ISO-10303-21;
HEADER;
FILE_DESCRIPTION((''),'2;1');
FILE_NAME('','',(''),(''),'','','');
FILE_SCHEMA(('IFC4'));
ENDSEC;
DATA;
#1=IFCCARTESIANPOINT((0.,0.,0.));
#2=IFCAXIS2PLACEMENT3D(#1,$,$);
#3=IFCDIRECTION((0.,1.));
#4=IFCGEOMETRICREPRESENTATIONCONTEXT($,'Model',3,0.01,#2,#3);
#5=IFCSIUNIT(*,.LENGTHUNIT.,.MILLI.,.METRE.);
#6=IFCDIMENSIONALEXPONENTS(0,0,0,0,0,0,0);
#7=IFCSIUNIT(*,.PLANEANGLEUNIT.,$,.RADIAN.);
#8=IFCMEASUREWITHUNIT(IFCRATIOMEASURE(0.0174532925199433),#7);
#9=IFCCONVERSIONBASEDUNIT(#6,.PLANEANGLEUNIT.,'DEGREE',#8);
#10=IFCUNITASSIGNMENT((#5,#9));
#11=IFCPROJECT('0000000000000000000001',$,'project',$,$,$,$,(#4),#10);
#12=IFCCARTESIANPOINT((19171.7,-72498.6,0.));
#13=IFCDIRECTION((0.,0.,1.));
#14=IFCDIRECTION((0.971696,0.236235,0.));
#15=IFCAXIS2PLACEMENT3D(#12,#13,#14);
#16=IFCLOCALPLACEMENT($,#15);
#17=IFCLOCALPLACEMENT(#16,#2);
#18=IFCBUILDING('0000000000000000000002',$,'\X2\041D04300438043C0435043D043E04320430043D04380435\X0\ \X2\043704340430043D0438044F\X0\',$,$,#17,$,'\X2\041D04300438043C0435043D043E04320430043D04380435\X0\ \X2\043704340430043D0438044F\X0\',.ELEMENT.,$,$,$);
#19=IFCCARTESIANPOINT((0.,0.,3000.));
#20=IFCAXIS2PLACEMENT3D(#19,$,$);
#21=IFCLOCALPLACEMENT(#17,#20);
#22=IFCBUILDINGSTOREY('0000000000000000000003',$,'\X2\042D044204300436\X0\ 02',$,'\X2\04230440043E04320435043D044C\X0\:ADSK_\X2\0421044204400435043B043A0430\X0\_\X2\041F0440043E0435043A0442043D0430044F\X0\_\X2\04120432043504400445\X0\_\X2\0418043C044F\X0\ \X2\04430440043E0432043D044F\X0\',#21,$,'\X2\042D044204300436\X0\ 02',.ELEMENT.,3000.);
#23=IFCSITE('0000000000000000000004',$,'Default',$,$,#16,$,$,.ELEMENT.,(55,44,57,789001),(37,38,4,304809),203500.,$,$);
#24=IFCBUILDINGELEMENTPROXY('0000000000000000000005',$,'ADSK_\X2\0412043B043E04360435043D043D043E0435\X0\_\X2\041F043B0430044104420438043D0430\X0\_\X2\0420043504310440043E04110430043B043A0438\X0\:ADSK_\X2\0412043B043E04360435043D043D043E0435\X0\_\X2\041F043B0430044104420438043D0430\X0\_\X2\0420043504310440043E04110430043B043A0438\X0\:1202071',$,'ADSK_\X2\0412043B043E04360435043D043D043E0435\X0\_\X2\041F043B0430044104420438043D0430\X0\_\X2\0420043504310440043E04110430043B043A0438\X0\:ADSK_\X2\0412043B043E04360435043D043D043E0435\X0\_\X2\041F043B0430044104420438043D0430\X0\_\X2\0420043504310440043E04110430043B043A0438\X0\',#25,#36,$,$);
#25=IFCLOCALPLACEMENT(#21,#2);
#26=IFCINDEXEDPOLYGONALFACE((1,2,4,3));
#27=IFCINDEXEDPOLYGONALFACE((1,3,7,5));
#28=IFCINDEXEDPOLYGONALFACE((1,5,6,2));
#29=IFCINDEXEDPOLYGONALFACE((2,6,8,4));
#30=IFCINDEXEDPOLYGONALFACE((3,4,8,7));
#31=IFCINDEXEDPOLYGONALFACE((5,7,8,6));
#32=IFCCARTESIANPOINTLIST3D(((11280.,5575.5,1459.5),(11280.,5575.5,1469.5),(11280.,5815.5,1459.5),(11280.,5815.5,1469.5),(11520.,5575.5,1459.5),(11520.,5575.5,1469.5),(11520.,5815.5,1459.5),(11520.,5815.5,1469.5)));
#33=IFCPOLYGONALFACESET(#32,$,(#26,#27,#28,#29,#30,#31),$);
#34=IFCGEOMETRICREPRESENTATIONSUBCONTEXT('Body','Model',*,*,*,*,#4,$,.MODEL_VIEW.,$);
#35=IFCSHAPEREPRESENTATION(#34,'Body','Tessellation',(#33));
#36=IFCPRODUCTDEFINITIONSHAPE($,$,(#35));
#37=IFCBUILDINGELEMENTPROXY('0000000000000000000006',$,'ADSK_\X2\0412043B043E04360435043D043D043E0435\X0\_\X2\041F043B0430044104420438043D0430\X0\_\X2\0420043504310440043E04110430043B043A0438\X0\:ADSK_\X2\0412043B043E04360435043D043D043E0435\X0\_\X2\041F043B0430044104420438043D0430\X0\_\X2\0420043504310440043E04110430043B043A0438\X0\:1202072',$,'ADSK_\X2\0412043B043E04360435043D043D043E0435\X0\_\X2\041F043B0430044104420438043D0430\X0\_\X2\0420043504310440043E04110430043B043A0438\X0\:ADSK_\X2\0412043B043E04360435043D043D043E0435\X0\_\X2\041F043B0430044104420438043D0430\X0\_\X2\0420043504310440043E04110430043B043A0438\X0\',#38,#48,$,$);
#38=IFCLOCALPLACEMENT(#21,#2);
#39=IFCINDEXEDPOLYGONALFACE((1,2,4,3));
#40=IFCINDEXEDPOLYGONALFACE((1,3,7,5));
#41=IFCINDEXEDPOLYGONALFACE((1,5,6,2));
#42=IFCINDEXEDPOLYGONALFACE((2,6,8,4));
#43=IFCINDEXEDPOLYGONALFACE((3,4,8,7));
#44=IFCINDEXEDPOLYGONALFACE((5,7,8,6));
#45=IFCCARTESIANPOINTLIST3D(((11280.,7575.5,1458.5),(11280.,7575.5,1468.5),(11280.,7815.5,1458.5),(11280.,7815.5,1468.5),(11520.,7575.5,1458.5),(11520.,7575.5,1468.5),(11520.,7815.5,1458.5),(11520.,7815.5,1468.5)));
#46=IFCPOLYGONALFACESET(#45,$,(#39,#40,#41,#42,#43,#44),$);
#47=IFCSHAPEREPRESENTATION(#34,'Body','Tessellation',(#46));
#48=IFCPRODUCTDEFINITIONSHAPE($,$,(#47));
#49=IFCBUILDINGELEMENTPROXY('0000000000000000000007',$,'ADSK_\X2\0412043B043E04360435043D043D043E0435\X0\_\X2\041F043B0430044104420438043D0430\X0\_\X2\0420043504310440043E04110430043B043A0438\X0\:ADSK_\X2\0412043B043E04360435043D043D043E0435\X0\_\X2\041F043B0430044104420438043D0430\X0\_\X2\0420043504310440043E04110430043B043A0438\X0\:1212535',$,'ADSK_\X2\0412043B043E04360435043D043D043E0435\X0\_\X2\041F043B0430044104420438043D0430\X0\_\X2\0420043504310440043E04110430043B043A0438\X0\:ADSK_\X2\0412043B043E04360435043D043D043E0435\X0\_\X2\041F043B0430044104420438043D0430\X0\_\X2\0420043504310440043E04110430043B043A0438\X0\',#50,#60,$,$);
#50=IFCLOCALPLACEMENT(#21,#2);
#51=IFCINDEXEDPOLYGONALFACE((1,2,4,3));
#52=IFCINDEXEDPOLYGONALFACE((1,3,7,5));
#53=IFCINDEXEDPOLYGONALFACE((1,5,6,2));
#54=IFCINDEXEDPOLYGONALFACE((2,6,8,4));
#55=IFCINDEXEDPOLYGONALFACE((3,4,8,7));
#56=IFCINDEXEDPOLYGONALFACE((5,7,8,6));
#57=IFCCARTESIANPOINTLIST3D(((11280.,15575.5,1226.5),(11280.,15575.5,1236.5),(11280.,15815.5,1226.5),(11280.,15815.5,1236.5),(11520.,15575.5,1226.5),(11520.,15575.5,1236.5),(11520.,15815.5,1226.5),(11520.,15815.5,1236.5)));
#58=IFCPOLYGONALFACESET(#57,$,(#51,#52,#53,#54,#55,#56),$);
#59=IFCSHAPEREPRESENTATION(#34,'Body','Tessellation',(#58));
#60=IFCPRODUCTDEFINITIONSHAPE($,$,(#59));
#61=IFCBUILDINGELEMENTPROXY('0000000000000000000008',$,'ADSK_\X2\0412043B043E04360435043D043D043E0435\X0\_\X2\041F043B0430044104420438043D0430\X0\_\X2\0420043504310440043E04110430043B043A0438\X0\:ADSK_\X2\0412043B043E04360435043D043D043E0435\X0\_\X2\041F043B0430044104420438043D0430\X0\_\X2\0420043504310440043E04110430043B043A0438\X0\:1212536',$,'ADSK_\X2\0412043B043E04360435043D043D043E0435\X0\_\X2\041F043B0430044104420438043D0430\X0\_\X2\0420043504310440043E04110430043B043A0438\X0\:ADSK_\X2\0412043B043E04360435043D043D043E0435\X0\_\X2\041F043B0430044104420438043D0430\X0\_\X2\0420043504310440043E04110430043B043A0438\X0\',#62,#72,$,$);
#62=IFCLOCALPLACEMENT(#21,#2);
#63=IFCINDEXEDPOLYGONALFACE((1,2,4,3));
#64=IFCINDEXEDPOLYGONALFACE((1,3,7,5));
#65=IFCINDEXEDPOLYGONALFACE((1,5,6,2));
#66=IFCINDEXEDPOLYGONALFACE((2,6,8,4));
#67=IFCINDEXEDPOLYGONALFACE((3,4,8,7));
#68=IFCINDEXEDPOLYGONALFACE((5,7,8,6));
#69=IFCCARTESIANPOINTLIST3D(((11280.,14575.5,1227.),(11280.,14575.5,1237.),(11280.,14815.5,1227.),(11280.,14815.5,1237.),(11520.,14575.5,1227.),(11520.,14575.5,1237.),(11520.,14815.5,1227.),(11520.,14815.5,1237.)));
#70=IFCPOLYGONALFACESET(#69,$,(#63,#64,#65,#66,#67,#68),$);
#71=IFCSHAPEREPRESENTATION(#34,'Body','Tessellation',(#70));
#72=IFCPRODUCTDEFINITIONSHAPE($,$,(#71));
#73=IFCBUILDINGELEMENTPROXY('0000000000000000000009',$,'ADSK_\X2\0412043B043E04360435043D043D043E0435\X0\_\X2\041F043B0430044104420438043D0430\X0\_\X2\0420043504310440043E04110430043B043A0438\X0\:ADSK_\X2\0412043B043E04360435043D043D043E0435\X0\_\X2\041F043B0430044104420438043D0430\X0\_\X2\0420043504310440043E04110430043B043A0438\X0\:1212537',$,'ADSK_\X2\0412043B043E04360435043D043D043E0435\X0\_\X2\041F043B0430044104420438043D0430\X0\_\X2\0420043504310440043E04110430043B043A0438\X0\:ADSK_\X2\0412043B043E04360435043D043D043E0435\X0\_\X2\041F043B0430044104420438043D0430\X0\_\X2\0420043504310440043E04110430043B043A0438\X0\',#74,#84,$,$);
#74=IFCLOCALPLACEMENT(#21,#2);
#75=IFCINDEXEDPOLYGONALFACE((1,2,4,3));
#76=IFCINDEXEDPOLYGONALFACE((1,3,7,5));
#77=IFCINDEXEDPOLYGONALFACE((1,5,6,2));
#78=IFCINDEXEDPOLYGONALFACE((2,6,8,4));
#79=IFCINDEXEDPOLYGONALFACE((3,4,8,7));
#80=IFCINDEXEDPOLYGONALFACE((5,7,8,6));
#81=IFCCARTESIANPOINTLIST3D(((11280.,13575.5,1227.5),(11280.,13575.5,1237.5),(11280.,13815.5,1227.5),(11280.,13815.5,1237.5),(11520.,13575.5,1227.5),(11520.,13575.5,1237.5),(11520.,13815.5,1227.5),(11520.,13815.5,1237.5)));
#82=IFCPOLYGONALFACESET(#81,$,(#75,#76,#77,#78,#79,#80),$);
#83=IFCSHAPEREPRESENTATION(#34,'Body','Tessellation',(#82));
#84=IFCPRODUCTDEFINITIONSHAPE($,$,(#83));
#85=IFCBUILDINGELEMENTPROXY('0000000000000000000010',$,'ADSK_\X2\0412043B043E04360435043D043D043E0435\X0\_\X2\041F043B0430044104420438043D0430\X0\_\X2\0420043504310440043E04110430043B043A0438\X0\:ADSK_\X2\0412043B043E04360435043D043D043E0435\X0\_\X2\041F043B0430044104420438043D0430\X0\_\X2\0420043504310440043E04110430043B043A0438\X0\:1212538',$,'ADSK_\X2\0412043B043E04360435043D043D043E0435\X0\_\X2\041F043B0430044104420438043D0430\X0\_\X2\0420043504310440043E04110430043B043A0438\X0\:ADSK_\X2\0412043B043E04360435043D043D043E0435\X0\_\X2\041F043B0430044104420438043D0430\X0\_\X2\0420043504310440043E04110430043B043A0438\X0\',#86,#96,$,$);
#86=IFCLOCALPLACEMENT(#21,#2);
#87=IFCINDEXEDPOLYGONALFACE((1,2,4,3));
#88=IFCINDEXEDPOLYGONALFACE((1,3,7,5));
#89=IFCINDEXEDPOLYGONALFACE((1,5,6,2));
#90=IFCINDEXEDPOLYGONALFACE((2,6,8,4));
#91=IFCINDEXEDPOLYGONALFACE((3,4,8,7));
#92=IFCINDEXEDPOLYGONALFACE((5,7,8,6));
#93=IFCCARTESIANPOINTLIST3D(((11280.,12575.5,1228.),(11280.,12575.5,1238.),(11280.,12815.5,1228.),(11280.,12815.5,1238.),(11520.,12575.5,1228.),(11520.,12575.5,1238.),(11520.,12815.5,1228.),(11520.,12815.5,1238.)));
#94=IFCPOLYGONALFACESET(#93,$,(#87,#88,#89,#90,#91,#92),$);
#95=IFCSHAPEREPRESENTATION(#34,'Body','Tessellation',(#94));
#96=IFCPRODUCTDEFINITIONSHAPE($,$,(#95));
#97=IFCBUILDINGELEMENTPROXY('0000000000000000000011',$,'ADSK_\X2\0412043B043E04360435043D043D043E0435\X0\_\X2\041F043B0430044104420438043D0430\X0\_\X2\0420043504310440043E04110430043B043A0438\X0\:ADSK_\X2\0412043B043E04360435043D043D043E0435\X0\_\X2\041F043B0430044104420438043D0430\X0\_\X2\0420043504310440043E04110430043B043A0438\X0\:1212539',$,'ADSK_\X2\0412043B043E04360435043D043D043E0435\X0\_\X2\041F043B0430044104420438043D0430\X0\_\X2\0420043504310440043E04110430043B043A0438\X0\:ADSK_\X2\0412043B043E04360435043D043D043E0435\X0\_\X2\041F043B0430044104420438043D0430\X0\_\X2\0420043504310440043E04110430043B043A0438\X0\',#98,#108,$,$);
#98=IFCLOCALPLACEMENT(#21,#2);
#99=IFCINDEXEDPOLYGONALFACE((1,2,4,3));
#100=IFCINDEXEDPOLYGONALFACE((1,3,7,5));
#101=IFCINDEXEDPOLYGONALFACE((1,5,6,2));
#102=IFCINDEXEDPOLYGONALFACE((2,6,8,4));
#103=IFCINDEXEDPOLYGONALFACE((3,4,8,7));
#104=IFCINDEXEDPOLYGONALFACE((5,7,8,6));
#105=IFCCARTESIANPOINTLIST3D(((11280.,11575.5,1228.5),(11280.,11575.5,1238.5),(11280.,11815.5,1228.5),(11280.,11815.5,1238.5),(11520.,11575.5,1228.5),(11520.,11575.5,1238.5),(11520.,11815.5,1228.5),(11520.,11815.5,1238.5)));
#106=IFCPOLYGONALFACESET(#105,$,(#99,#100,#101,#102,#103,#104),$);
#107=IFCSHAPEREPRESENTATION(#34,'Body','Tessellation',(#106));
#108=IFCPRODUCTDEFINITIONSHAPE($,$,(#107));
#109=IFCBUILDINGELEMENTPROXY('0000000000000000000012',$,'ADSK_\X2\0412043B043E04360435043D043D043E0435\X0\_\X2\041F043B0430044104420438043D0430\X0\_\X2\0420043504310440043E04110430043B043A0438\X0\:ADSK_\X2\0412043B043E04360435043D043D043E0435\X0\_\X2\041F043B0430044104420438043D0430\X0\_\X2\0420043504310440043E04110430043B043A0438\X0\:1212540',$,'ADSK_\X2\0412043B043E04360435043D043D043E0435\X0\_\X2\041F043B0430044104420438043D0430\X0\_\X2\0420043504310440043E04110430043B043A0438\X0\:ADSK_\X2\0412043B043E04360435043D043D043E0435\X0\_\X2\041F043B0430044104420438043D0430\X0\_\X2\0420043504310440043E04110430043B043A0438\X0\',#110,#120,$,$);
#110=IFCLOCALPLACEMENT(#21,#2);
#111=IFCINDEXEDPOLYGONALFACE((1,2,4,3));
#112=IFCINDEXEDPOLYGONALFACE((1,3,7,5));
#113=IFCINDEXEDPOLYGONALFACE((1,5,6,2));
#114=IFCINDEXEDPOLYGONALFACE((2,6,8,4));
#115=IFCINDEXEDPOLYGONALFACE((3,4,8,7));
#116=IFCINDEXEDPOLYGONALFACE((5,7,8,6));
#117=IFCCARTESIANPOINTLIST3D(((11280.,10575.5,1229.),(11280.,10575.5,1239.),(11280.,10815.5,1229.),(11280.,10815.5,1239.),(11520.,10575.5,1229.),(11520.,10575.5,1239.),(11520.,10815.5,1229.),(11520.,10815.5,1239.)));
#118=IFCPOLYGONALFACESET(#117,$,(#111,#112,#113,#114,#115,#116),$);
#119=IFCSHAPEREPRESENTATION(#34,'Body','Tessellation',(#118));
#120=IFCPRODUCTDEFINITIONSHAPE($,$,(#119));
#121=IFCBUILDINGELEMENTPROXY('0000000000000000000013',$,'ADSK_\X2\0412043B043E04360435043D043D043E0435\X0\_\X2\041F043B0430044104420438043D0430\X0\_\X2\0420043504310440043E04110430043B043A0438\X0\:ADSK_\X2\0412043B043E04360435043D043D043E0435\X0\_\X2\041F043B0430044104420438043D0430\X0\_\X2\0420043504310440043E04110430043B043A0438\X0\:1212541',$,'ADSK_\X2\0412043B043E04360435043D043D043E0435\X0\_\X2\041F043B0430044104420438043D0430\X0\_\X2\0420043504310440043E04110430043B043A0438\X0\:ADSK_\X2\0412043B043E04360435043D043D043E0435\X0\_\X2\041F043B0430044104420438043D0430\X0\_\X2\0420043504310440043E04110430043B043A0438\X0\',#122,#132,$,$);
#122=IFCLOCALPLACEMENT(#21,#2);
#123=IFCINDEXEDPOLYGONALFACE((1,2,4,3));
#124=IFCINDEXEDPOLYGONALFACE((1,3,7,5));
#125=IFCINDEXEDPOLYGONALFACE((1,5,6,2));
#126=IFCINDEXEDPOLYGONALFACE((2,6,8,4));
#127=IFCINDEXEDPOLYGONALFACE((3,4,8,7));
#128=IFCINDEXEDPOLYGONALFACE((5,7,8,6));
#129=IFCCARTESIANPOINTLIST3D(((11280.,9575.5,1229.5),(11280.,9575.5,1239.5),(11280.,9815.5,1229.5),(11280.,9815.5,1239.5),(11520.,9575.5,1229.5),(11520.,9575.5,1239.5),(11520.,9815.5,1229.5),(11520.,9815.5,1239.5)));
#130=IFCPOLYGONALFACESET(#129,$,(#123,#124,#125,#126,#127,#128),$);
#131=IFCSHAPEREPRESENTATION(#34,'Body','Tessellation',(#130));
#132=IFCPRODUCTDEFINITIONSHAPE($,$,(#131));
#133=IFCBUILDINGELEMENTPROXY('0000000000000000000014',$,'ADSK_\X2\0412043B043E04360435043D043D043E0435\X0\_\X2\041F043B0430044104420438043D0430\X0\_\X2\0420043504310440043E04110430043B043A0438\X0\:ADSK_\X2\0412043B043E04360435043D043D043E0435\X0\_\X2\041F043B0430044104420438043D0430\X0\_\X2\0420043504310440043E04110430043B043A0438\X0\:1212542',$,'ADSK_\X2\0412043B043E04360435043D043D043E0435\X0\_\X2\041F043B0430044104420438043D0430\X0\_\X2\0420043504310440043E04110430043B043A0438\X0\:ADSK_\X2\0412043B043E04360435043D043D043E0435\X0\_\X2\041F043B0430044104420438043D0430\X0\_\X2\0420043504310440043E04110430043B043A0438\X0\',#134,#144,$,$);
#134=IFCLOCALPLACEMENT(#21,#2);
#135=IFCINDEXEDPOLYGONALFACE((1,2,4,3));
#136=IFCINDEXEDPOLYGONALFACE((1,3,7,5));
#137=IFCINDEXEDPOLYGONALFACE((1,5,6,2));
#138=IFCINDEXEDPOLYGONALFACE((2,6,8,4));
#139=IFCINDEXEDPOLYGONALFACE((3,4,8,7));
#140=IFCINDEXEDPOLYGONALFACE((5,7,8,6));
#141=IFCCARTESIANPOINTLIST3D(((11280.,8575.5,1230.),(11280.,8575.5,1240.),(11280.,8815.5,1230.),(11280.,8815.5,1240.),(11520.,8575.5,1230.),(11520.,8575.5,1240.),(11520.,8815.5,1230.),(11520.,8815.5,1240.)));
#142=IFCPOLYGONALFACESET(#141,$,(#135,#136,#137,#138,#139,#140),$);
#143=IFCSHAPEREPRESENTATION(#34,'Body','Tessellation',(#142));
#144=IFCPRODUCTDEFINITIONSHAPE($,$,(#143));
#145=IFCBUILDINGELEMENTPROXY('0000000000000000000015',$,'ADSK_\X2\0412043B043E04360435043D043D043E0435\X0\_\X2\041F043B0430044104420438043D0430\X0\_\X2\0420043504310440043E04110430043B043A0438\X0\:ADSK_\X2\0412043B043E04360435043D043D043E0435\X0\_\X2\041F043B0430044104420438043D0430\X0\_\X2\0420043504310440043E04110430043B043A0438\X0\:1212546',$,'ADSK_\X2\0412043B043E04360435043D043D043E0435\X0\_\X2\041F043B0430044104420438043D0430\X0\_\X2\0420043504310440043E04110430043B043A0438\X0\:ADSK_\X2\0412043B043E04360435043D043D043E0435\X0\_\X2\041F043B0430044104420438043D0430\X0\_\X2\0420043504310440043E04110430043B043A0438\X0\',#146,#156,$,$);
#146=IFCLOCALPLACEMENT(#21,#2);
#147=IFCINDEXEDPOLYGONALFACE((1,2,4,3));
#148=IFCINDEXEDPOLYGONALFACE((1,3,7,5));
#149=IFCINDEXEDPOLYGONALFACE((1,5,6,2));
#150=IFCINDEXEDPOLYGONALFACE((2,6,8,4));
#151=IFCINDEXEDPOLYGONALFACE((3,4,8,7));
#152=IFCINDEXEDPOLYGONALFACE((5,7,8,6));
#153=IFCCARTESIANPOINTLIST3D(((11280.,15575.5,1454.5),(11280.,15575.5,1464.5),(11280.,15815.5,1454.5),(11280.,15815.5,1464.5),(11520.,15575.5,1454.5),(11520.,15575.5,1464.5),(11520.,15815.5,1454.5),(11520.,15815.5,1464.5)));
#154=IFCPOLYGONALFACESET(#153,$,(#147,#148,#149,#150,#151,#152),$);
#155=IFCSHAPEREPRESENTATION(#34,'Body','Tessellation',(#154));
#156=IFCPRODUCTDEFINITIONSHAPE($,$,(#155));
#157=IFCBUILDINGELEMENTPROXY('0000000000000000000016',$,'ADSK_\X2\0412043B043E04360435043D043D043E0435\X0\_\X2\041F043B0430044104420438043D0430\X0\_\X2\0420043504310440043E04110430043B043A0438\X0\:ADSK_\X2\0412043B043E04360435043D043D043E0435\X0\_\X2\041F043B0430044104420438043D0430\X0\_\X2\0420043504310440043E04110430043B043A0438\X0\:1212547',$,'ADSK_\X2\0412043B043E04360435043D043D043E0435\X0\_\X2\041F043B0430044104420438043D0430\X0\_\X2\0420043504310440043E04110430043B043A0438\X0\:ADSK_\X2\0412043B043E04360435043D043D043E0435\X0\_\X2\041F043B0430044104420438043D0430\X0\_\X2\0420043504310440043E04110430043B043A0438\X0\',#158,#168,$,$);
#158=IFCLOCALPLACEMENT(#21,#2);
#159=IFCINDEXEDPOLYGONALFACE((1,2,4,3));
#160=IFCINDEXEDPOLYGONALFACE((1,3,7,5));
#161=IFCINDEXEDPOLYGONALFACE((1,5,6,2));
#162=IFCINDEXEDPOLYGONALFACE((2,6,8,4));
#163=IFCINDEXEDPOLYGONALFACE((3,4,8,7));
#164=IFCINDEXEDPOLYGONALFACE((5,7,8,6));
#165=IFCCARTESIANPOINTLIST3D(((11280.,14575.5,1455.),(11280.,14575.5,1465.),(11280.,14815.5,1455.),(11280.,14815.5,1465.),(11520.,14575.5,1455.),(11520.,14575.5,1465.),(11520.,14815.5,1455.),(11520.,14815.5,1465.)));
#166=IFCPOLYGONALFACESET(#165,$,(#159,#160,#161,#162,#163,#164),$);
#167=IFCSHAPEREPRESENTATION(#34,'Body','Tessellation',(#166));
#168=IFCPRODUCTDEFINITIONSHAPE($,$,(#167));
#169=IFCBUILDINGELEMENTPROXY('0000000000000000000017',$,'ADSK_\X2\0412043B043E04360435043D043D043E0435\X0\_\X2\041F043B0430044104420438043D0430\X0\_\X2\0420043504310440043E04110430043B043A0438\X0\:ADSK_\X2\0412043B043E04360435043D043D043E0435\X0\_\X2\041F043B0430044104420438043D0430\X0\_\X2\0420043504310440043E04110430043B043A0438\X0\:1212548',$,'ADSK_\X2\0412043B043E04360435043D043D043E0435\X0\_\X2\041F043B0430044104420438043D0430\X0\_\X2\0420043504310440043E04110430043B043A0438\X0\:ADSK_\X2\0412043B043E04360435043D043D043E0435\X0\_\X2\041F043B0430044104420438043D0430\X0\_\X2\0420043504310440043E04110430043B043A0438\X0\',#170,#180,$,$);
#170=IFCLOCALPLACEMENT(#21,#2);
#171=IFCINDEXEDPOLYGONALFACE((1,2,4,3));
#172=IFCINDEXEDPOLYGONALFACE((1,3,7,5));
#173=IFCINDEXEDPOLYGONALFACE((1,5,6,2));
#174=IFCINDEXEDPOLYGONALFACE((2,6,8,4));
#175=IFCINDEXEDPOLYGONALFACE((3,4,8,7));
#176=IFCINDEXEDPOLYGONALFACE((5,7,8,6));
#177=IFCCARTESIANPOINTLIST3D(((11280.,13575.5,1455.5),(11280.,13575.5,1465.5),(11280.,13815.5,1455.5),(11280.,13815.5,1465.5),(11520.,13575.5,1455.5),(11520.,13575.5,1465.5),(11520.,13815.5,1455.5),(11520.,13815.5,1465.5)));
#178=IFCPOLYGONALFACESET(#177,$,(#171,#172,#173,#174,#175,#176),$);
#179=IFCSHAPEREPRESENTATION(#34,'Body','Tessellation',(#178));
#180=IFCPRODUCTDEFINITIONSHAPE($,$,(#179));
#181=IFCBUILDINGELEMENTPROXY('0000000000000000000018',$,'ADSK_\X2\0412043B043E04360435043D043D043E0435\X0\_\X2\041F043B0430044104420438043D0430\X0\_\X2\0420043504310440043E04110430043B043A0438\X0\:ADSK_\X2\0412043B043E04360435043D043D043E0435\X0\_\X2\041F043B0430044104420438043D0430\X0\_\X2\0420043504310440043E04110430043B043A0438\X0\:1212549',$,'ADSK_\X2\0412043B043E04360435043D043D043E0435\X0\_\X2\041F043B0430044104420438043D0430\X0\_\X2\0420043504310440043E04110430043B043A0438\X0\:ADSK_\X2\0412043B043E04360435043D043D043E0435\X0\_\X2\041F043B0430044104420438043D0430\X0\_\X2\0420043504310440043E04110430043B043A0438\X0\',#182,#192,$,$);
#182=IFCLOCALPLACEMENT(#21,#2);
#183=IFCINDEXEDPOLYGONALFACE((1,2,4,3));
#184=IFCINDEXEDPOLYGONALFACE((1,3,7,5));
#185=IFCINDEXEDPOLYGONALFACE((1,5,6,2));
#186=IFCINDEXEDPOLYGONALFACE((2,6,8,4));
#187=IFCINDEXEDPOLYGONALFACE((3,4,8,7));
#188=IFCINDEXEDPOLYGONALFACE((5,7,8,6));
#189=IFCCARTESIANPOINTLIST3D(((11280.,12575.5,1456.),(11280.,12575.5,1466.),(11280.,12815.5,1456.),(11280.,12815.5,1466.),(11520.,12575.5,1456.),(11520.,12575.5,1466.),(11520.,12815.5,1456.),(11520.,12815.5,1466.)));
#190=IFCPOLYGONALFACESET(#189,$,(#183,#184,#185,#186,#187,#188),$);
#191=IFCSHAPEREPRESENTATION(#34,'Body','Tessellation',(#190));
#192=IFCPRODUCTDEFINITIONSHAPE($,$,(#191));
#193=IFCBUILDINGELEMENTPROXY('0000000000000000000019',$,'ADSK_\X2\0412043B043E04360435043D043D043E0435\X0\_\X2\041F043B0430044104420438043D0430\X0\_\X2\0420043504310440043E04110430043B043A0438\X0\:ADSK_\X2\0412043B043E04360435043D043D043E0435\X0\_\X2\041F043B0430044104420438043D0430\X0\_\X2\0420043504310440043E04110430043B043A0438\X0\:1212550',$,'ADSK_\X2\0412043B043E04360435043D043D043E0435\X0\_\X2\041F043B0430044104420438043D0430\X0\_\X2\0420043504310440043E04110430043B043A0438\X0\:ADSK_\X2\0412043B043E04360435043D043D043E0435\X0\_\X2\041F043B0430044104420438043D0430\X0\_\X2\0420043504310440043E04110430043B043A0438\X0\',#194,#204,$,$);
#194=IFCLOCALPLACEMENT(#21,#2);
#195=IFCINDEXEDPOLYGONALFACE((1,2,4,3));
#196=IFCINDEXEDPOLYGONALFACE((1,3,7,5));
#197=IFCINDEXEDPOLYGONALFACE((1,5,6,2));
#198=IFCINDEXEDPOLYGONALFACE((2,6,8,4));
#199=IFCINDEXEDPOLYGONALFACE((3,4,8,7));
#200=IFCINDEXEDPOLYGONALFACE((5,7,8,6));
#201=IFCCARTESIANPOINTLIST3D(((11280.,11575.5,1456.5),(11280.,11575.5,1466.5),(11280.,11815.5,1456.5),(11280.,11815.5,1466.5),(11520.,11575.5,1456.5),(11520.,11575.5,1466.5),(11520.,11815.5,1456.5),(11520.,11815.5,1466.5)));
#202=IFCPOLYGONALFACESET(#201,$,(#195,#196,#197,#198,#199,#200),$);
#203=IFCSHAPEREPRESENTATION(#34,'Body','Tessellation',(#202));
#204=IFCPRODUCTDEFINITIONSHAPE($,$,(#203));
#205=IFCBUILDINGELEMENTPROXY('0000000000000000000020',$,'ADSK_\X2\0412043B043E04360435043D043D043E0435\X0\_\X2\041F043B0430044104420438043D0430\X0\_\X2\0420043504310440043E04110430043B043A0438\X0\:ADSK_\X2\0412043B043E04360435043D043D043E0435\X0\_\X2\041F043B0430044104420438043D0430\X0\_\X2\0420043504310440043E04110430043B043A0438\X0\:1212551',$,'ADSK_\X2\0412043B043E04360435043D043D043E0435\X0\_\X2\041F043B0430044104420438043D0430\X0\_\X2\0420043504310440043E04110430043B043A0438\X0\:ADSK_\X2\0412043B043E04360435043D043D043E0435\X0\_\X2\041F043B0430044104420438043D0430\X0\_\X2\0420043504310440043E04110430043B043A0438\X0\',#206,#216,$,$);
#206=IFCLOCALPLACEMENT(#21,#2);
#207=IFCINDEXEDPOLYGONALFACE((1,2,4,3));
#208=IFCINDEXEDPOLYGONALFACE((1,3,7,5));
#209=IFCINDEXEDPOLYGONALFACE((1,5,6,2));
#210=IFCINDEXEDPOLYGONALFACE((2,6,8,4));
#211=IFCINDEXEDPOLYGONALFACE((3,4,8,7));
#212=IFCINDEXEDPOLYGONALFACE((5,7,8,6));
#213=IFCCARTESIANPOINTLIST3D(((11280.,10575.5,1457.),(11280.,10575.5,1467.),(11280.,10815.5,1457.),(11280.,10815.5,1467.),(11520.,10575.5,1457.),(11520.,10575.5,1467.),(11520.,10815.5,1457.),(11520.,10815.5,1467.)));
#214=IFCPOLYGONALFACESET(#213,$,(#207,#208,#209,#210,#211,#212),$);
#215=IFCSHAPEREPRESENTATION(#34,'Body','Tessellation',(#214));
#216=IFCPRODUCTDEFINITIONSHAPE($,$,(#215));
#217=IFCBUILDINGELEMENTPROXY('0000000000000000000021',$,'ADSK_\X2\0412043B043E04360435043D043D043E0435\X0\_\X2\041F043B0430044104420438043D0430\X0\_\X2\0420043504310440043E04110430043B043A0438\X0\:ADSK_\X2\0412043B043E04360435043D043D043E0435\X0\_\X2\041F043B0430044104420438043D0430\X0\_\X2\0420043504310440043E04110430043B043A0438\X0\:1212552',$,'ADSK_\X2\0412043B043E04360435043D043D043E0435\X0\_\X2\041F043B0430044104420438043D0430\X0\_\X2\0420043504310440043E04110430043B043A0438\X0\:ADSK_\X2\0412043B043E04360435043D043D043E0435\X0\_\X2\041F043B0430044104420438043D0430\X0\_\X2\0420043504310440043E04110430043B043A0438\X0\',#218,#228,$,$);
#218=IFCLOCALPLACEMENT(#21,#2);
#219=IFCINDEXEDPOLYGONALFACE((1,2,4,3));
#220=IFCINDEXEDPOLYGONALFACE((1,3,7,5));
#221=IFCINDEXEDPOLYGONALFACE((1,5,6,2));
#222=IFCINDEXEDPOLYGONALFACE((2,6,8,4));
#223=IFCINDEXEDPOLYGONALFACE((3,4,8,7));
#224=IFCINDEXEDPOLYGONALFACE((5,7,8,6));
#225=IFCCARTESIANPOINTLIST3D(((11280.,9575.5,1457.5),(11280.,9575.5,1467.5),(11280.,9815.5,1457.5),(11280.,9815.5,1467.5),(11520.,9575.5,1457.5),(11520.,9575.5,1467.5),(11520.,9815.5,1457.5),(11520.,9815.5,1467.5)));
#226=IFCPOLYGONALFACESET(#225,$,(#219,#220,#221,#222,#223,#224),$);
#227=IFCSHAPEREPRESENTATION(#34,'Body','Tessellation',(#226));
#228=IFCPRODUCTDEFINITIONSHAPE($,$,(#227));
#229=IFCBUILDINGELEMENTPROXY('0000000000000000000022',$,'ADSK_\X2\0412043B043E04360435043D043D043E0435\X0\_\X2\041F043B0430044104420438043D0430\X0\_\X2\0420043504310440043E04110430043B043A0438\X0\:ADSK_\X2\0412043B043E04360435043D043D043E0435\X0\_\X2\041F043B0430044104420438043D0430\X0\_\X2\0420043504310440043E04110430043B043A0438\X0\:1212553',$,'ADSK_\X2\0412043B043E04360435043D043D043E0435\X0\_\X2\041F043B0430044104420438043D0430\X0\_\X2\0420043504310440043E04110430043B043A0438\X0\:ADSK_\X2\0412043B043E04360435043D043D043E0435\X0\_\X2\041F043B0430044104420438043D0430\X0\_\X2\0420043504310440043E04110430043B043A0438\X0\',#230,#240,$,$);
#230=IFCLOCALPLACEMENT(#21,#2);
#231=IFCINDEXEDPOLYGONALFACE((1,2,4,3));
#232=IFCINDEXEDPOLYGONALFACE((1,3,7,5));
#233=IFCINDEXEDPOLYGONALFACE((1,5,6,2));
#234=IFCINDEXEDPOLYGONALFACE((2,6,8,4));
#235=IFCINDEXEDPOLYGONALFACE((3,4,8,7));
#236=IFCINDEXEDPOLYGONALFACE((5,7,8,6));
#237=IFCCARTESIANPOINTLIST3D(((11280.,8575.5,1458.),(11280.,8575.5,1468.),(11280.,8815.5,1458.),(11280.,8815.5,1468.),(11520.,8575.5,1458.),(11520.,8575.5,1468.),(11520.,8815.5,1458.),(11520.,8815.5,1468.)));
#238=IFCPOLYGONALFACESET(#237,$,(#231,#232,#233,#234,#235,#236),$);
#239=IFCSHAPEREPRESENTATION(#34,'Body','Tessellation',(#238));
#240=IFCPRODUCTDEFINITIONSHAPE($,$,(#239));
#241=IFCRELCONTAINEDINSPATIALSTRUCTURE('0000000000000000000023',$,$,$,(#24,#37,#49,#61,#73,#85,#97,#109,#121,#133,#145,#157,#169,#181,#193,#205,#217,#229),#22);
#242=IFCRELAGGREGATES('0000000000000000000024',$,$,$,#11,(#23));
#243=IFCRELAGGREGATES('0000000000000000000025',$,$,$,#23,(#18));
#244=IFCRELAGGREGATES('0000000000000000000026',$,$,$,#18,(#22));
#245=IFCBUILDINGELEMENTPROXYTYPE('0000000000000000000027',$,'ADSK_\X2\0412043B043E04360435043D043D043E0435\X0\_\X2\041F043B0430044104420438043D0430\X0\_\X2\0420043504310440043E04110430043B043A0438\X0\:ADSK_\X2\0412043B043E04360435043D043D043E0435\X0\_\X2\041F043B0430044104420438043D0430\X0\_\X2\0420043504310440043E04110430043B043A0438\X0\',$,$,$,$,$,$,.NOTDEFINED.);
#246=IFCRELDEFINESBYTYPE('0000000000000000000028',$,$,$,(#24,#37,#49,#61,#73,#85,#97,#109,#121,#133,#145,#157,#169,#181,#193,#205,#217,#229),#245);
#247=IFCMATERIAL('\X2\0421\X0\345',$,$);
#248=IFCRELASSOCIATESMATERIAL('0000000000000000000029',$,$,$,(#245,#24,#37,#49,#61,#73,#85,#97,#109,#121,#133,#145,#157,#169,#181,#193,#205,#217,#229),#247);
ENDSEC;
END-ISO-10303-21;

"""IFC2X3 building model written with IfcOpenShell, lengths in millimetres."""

from ifc_helpers import new_model, entity, si_unit, converted_unit, direction, frame, origin, origin_2d_with_axis, place, context, subcontext, project, spatial, rectangle, extrude, source, transform, mapped, material, type_object, type_shapes, element, save


model = new_model("IFC2X3")

# Units and contexts
model_context = context("Model", 3, precision=0.01, world=origin(), true_north=direction((0.0, 1.0)))
body_context = subcontext(model_context, "Body", "Model", "MODEL_VIEW")
ifc_project = project(units=[si_unit("LENGTHUNIT", "METRE", prefix="MILLI"), converted_unit("PLANEANGLEUNIT", "DEGREE", entity("IfcRatioMeasure", 0.0174532925199433), si_unit("PLANEANGLEUNIT", "RADIAN"), dimensions=[0, 0, 0, 0, 0, 0, 0])], contexts=[model_context])

# Site, building, storey
site_placement = place(None, frame((19171.7, -72498.6, 0.0), z_axis=(0.0, 0.0, 1.0), x_axis=(0.971696, 0.236235, 0.0)))
site = spatial("IfcSite", under=ifc_project, at=site_placement, Name="Default", CompositionType="ELEMENT", RefLatitude=(55, 44, 57, 789001), RefLongitude=(37, 38, 4, 304809), RefElevation=203500.0)
building_placement = place(site_placement, origin())
building = spatial("IfcBuilding", under=site, at=building_placement, Name="Наименование здания", LongName="Наименование здания", CompositionType="ELEMENT")
storey_placement = place(building_placement, frame((0.0, 0.0, 3000.0)))
storey = spatial("IfcBuildingStorey", under=building, at=storey_placement, Name="Этаж 02", ObjectType="Уровень:ADSK_Стрелка_Проектная_Вверх_Имя уровня", LongName="Этаж 02", CompositionType="ELEMENT", Elevation=3000.0)

# Shared definitions
ifc_material_1 = material(Name="С345")

# Building element proxies
building_element_proxy_type = type_object("IfcBuildingElementProxyType", Name="ADSK_Вложенное_Пластина_РеброБалки:ADSK_Вложенное_Пластина_РеброБалки", PredefinedType="NOTDEFINED", material=ifc_material_1)
shared_shape_1 = source(origin(), body_context, "Body", "SweptSolid", [
    extrude(rectangle(XDim=10.0, YDim=240.0, at=origin_2d_with_axis()), frame((0.0, 0.0, -120.0), z_axis=(0.0, 0.0, 1.0), x_axis=(0.0, 1.0, 0.0)), (0.0, 0.0, 1.0), 240.0),
])
type_shapes(building_element_proxy_type, [shared_shape_1])
for number, where, z_axis, x_axis, name in (
    (1, (11400.0, 5695.5, 1464.5), (0.0, 1.0, 0.0), (1.0, 0.0, 0.0), "ADSK_Вложенное_Пластина_РеброБалки:ADSK_Вложенное_Пластина_РеброБалки:1202071"),
    (2, (11400.0, 7695.5, 1463.5), (0.0, 1.0, 0.0), (1.0, 0.0, 0.0), "ADSK_Вложенное_Пластина_РеброБалки:ADSK_Вложенное_Пластина_РеброБалки:1202072"),
    (3, (11400.0, 15695.5, 1231.5), (0.0, 1.0, 0.0), (1.0, 0.0, 0.0), "ADSK_Вложенное_Пластина_РеброБалки:ADSK_Вложенное_Пластина_РеброБалки:1212535"),
    (4, (11400.0, 14695.5, 1232.0), (0.0, 1.0, 0.0), (1.0, 0.0, 0.0), "ADSK_Вложенное_Пластина_РеброБалки:ADSK_Вложенное_Пластина_РеброБалки:1212536"),
    (5, (11400.0, 13695.5, 1232.5), (0.0, 1.0, 0.0), (1.0, 0.0, 0.0), "ADSK_Вложенное_Пластина_РеброБалки:ADSK_Вложенное_Пластина_РеброБалки:1212537"),
    (6, (11400.0, 12695.5, 1233.0), (0.0, 1.0, 0.0), (1.0, 0.0, 0.0), "ADSK_Вложенное_Пластина_РеброБалки:ADSK_Вложенное_Пластина_РеброБалки:1212538"),
    (7, (11400.0, 11695.5, 1233.5), (0.0, 1.0, 0.0), (1.0, 0.0, 0.0), "ADSK_Вложенное_Пластина_РеброБалки:ADSK_Вложенное_Пластина_РеброБалки:1212539"),
    (8, (11400.0, 10695.5, 1234.0), (0.0, 1.0, 0.0), (1.0, 0.0, 0.0), "ADSK_Вложенное_Пластина_РеброБалки:ADSK_Вложенное_Пластина_РеброБалки:1212540"),
    (9, (11400.0, 9695.5, 1234.5), (0.0, 1.0, 0.0), (1.0, 0.0, 0.0), "ADSK_Вложенное_Пластина_РеброБалки:ADSK_Вложенное_Пластина_РеброБалки:1212541"),
    (10, (11400.0, 8695.5, 1235.0), (0.0, 1.0, 0.0), (1.0, 0.0, 0.0), "ADSK_Вложенное_Пластина_РеброБалки:ADSK_Вложенное_Пластина_РеброБалки:1212542"),
    (11, (11400.0, 15695.5, 1459.5), (0.0, 1.0, 0.0), (1.0, 0.0, 0.0), "ADSK_Вложенное_Пластина_РеброБалки:ADSK_Вложенное_Пластина_РеброБалки:1212546"),
    (12, (11400.0, 14695.5, 1460.0), (0.0, 1.0, 0.0), (1.0, 0.0, 0.0), "ADSK_Вложенное_Пластина_РеброБалки:ADSK_Вложенное_Пластина_РеброБалки:1212547"),
    (13, (11400.0, 13695.5, 1460.5), (0.0, 1.0, 0.0), (1.0, 0.0, 0.0), "ADSK_Вложенное_Пластина_РеброБалки:ADSK_Вложенное_Пластина_РеброБалки:1212548"),
    (14, (11400.0, 12695.5, 1461.0), (0.0, 1.0, 0.0), (1.0, 0.0, 0.0), "ADSK_Вложенное_Пластина_РеброБалки:ADSK_Вложенное_Пластина_РеброБалки:1212549"),
    (15, (11400.0, 11695.5, 1461.5), (0.0, 1.0, 0.0), (1.0, 0.0, 0.0), "ADSK_Вложенное_Пластина_РеброБалки:ADSK_Вложенное_Пластина_РеброБалки:1212550"),
    (16, (11400.0, 10695.5, 1462.0), (0.0, 1.0, 0.0), (1.0, 0.0, 0.0), "ADSK_Вложенное_Пластина_РеброБалки:ADSK_Вложенное_Пластина_РеброБалки:1212551"),
    (17, (11400.0, 9695.5, 1462.5), (0.0, 1.0, 0.0), (1.0, 0.0, 0.0), "ADSK_Вложенное_Пластина_РеброБалки:ADSK_Вложенное_Пластина_РеброБалки:1212552"),
    (18, (11400.0, 8695.5, 1463.0), (0.0, 1.0, 0.0), (1.0, 0.0, 0.0), "ADSK_Вложенное_Пластина_РеброБалки:ADSK_Вложенное_Пластина_РеброБалки:1212553"),
):
    element("IfcBuildingElementProxy", number, at=place(storey_placement, frame(where, z_axis=z_axis, x_axis=x_axis)), inside=storey, type_object=building_element_proxy_type, material=ifc_material_1, Name=name, ObjectType="ADSK_Вложенное_Пластина_РеброБалки:ADSK_Вложенное_Пластина_РеброБалки", context=body_context, shape_type="MappedRepresentation", body=[
        mapped(shared_shape_1, transform((0.0, 0.0, 0.0), scale=1.0)),
    ])

save(model, "model.ifc")
